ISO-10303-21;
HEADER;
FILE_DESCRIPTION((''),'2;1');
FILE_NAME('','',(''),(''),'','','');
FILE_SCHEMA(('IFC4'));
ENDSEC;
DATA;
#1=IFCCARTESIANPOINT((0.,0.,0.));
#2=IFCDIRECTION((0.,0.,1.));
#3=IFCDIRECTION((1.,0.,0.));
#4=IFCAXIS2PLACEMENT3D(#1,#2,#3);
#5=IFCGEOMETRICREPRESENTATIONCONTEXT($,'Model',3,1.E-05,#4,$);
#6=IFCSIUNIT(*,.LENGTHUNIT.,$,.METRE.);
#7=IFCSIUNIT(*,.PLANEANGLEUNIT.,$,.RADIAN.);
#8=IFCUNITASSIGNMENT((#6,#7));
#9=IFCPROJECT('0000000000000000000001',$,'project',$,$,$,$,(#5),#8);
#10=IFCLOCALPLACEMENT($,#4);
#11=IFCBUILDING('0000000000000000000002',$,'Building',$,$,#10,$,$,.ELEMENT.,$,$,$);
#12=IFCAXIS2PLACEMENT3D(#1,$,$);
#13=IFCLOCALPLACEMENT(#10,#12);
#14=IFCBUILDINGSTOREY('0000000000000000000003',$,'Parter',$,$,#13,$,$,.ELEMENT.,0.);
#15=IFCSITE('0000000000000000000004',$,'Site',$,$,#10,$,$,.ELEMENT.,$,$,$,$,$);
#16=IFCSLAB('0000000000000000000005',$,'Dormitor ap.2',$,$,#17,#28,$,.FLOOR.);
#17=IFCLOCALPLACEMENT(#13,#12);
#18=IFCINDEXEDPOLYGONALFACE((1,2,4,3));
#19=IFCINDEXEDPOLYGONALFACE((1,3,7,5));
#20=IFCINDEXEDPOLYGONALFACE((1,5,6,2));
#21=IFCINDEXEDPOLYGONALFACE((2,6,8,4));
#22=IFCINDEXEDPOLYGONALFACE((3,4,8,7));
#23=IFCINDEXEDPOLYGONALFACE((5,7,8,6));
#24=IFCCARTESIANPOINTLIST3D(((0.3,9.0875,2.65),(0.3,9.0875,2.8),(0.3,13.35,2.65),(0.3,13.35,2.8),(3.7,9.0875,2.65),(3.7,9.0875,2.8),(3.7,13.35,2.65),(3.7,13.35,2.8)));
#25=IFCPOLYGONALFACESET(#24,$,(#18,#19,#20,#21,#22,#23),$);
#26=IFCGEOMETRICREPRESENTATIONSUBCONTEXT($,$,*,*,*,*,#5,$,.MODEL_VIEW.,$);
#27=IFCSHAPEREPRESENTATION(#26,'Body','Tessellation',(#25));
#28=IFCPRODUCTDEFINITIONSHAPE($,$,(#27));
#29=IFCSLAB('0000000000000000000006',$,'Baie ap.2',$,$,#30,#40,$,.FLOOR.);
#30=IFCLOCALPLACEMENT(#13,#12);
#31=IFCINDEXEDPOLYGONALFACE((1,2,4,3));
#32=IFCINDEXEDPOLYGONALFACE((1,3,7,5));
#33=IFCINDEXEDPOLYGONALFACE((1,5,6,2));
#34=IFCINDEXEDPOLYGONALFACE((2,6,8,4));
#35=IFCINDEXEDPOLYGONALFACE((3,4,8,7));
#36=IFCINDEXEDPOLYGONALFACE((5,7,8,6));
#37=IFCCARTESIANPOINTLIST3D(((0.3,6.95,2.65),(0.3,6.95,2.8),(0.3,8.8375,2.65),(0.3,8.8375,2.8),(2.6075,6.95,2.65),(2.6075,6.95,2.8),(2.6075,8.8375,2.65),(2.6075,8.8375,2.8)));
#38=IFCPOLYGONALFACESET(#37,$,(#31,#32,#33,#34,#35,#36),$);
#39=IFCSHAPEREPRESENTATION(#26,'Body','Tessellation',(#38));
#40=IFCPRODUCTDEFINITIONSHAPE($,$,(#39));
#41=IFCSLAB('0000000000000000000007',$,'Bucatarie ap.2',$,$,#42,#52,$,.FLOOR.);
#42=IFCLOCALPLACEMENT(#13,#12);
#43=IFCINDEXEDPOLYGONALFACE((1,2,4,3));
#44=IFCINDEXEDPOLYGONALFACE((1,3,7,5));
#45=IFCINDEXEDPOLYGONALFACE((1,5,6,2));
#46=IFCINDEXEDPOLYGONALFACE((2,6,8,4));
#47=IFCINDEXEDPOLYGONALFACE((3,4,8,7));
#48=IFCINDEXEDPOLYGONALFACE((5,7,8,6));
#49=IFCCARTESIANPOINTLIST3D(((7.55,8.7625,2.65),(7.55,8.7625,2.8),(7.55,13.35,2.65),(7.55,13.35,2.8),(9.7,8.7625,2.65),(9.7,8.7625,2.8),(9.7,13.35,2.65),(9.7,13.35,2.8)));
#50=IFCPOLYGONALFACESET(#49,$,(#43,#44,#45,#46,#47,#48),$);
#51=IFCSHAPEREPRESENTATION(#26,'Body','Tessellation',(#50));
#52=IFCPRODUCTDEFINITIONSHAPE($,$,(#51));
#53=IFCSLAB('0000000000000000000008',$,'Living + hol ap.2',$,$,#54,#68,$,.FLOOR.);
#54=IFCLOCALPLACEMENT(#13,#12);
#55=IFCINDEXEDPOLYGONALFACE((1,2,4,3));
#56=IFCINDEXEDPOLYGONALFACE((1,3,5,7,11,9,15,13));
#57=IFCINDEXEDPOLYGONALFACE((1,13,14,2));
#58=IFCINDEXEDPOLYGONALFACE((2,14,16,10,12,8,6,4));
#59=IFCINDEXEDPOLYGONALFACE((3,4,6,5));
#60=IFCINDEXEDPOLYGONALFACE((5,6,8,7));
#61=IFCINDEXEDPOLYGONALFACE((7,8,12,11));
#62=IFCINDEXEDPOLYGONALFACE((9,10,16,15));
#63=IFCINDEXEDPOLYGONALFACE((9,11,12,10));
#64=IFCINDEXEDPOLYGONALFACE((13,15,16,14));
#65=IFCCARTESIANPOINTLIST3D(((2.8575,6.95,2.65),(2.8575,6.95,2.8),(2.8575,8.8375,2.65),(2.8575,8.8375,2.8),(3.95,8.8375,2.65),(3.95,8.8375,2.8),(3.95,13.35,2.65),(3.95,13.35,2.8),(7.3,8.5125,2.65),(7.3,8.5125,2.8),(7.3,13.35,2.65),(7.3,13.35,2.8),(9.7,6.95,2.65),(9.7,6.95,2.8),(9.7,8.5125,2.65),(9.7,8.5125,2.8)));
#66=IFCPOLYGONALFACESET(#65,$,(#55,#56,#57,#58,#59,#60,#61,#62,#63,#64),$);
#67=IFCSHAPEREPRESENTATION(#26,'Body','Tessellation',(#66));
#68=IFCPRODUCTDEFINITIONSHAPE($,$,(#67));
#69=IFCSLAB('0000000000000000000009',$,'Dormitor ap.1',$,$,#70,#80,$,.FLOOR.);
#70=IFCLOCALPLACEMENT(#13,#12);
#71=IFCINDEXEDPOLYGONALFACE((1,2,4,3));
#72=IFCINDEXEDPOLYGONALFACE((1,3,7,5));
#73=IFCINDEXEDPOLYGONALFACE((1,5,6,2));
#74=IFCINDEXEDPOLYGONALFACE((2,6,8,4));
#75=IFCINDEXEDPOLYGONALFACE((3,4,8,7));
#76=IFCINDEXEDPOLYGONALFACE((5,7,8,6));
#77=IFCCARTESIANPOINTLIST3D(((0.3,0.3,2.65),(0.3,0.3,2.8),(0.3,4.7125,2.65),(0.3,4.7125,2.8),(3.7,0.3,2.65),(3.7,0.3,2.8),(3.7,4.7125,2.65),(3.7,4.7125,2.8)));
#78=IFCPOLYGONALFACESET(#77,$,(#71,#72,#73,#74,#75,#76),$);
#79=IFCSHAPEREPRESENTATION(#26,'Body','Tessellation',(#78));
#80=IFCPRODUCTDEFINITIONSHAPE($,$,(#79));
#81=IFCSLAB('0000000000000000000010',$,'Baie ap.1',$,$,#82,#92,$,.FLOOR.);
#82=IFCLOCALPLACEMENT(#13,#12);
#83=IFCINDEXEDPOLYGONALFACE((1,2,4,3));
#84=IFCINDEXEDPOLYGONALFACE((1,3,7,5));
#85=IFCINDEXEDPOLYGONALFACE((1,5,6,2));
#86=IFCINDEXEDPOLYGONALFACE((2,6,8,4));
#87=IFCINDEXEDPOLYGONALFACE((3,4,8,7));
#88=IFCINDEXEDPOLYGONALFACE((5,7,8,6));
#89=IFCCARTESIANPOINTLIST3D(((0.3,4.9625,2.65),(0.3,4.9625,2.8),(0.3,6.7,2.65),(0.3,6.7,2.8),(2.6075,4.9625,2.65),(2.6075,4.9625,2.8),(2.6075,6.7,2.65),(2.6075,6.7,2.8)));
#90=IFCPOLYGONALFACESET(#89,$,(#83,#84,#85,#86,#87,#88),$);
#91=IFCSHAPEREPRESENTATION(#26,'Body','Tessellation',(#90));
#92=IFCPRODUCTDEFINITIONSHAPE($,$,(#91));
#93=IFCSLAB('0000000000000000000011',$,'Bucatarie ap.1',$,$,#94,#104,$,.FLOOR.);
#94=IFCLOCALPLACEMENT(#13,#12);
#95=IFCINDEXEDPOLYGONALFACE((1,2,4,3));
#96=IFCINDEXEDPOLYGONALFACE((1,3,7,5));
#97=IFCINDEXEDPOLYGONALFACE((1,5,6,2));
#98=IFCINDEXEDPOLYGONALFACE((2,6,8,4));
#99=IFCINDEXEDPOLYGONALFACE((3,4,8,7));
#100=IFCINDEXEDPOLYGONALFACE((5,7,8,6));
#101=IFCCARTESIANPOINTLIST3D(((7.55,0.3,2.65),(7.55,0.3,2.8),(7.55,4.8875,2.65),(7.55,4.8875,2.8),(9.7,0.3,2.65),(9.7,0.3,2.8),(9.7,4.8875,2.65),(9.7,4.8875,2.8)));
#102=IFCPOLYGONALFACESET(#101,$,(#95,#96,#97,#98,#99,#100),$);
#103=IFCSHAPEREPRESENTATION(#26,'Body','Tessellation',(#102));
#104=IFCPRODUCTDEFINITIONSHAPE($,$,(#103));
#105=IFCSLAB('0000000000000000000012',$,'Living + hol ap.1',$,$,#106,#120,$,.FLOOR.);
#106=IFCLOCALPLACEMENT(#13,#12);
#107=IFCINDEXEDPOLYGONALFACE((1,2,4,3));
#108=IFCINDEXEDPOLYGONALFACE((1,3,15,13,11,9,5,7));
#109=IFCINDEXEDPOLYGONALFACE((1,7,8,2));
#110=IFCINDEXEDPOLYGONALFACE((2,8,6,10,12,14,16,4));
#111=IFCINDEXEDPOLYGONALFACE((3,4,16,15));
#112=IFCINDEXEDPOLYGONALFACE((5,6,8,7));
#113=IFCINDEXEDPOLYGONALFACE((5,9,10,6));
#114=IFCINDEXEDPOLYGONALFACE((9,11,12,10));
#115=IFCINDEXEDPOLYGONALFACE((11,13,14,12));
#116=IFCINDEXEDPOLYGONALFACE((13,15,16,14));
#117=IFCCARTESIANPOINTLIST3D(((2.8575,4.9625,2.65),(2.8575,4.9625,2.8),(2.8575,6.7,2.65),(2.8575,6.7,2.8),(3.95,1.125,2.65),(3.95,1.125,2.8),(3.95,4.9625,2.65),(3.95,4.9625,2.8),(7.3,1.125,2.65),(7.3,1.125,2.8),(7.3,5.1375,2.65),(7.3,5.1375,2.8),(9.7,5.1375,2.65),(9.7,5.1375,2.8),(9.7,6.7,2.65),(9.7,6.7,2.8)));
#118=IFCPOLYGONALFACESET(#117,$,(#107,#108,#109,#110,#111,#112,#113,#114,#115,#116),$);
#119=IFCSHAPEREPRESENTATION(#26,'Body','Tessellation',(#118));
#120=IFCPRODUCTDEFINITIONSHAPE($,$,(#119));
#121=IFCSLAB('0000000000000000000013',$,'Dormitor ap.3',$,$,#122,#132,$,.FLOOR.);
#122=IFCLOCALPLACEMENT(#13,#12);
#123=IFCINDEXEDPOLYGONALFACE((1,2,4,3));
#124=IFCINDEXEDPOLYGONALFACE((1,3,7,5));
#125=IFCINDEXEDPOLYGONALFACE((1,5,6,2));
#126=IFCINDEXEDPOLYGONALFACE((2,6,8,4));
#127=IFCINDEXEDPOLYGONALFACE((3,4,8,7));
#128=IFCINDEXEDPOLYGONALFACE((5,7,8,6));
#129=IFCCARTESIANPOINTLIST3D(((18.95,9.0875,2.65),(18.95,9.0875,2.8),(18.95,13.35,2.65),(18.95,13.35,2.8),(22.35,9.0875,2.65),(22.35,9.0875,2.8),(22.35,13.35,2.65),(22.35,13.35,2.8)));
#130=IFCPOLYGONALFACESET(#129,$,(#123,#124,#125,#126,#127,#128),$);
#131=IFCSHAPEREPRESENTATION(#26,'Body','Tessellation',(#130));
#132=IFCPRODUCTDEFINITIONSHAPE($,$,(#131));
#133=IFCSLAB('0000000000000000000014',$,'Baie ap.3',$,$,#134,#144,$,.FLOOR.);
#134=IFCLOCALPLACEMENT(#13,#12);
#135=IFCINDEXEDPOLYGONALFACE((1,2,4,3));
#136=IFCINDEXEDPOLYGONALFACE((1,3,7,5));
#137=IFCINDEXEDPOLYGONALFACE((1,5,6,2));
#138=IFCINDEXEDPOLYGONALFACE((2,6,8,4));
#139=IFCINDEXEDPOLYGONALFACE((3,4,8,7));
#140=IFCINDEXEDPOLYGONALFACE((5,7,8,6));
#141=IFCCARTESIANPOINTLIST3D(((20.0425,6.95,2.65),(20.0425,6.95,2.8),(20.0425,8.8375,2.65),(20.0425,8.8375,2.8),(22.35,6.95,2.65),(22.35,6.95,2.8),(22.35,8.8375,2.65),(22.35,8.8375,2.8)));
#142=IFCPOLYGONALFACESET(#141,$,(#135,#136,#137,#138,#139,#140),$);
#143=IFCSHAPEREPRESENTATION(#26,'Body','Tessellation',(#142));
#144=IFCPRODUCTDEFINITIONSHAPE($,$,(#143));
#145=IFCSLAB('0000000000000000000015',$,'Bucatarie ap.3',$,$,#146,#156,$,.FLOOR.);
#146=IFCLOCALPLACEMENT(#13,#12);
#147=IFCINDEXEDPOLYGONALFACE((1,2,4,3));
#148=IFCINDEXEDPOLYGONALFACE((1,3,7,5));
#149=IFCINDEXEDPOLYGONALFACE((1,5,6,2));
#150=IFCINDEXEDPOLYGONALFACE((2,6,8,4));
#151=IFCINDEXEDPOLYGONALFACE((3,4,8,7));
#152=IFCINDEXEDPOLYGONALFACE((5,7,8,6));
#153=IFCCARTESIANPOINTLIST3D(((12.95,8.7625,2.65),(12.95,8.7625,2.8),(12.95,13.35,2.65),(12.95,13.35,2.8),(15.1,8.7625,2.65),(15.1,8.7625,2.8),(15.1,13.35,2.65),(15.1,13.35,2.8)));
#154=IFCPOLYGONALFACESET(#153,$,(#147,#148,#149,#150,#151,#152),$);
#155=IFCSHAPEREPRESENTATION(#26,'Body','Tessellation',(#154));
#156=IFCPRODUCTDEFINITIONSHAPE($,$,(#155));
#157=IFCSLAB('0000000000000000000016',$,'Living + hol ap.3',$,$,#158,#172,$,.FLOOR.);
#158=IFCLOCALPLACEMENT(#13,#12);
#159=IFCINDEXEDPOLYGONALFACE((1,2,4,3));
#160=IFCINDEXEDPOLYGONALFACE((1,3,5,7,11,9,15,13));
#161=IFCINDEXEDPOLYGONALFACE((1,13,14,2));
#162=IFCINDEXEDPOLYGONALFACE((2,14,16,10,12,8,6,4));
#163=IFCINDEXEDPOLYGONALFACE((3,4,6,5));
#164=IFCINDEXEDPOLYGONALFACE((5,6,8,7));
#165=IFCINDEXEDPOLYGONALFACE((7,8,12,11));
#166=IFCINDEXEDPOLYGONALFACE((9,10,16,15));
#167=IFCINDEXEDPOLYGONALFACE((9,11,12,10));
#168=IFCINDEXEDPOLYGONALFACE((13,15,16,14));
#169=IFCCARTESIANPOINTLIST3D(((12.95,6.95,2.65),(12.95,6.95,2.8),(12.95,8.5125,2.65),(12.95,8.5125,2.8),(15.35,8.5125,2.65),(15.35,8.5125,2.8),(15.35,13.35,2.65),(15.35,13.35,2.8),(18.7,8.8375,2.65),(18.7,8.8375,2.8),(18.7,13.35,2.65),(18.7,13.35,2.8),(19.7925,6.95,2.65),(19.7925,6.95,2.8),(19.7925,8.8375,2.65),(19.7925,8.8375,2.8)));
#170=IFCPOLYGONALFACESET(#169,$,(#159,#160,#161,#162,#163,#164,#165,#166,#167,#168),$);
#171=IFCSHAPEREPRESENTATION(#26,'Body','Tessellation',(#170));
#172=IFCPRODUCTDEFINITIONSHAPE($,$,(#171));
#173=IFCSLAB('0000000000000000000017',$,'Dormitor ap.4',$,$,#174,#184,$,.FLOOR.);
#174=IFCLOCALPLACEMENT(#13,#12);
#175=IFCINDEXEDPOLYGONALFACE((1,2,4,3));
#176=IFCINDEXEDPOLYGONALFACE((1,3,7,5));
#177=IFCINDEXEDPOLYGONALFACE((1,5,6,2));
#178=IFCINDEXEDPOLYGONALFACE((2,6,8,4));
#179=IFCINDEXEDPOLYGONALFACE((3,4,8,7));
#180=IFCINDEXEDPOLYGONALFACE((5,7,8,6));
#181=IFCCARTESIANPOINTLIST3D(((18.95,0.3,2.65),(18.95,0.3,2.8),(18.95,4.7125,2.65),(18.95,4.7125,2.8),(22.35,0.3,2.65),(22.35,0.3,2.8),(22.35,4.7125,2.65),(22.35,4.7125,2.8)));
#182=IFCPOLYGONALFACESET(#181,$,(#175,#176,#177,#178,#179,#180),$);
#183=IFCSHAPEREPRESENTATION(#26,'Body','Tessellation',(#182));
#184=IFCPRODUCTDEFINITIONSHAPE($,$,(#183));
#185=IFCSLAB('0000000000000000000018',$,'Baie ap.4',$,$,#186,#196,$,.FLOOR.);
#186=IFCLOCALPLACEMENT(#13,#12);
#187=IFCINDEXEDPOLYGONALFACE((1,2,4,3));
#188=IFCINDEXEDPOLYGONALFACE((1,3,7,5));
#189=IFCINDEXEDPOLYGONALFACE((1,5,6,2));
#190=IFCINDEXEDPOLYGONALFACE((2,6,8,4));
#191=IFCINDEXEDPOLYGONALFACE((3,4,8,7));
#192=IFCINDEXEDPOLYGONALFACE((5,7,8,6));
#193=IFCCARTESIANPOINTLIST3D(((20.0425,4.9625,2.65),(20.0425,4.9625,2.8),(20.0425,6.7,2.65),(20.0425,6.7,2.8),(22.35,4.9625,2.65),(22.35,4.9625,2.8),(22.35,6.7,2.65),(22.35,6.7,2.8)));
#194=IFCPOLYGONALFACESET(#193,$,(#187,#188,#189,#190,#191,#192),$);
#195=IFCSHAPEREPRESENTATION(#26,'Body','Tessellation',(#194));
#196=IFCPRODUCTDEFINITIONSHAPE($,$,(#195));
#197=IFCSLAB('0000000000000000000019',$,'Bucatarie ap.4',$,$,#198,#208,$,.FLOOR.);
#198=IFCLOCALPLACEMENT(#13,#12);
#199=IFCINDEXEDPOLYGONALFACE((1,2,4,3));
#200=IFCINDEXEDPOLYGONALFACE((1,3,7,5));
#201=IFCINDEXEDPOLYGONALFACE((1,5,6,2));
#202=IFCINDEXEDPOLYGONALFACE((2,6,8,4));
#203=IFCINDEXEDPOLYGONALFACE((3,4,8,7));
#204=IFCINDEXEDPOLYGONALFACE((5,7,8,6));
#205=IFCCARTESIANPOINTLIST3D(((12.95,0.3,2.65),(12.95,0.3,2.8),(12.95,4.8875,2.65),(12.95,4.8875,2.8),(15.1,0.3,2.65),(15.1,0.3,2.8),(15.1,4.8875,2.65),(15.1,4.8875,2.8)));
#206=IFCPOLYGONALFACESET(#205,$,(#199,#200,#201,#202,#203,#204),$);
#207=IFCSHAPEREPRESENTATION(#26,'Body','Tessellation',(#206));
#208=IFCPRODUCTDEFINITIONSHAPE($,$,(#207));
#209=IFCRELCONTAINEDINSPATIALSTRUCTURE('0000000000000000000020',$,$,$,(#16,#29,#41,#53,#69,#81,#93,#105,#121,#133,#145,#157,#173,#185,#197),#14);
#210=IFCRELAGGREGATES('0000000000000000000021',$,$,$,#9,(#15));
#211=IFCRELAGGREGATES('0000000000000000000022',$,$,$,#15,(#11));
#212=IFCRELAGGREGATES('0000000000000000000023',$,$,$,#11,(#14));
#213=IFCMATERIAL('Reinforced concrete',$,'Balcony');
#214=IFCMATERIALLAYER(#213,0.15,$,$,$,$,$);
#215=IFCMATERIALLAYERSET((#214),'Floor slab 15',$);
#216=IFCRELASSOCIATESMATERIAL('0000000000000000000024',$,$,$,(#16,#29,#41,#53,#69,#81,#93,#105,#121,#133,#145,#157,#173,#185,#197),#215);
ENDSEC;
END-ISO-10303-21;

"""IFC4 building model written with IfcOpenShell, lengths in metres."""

from ifc_helpers import new_model, si_unit, frame, origin, origin_with_axes, place, context, subcontext, project, spatial, polyline, outline, extrude, material, layer, layer_set, layer_usage, element, save


model = new_model("IFC4")

# Units and contexts
model_context = context("Model", 3, precision=1e-05, world=origin_with_axes())
sub_context = subcontext(model_context, None, None, "MODEL_VIEW")
ifc_project = project(units=[si_unit("LENGTHUNIT", "METRE"), si_unit("PLANEANGLEUNIT", "RADIAN")], contexts=[model_context])

# Site, building, storey
placement = place(None, origin_with_axes())
site = spatial("IfcSite", under=ifc_project, at=placement, Name="Site", CompositionType="ELEMENT")
building = spatial("IfcBuilding", under=site, at=placement, Name="Building", CompositionType="ELEMENT")
storey_placement = place(placement, origin())
storey = spatial("IfcBuildingStorey", under=building, at=storey_placement, Name="Parter", CompositionType="ELEMENT", Elevation=0.0)

# Slabs
ifc_material_1 = material(Name="Reinforced concrete", Category="Balcony")
ifc_layer = layer(ifc_material_1, 0.15)
ifc_layer_set = layer_set([ifc_layer], Name="Floor slab 15")
ifc_layer_usage = layer_usage(ifc_layer_set, "AXIS3", "POSITIVE", 0.0)
slab_1_placement = place(storey_placement, frame((0.0, 0.0, 2.65)))
element("IfcSlab", 1, at=slab_1_placement, inside=storey, material=ifc_layer_usage, Name="Dormitor ap.2", PredefinedType="FLOOR", context=sub_context, shape_type="SweptSolid", body=[
    extrude(outline(polyline([(3.7, 13.35), (0.3, 13.35), (0.3, 9.0875), (3.7, 9.0875), (3.7, 13.35)])), origin(), (0.0, 0.0, 1.0), 0.15),
])
slab_2_placement = place(storey_placement, frame((0.0, 0.0, 2.65)))
element("IfcSlab", 2, at=slab_2_placement, inside=storey, material=ifc_layer_usage, Name="Baie ap.2", PredefinedType="FLOOR", context=sub_context, shape_type="SweptSolid", body=[
    extrude(outline(polyline([(2.6075, 8.8375), (0.3, 8.8375), (0.3, 6.95), (2.6075, 6.95), (2.6075, 8.8375)])), origin(), (0.0, 0.0, 1.0), 0.15),
])
slab_3_placement = place(storey_placement, frame((0.0, 0.0, 2.65)))
element("IfcSlab", 3, at=slab_3_placement, inside=storey, material=ifc_layer_usage, Name="Bucatarie ap.2", PredefinedType="FLOOR", context=sub_context, shape_type="SweptSolid", body=[
    extrude(outline(polyline([(7.55, 13.35), (7.55, 8.7625), (9.7, 8.7625), (9.7, 13.35), (7.55, 13.35)])), origin(), (0.0, 0.0, 1.0), 0.15),
])
slab_4_placement = place(storey_placement, frame((0.0, 0.0, 2.65)))
element("IfcSlab", 4, at=slab_4_placement, inside=storey, material=ifc_layer_usage, Name="Living + hol ap.2", PredefinedType="FLOOR", context=sub_context, shape_type="SweptSolid", body=[
    extrude(outline(polyline([(7.3, 13.35), (3.95, 13.35), (3.95, 8.8375), (2.8575, 8.8375), (2.8575, 6.95), (9.7, 6.95), (9.7, 8.5125), (7.3, 8.5125), (7.3, 13.35)])), origin(), (0.0, 0.0, 1.0), 0.15),
])
slab_5_placement = place(storey_placement, frame((0.0, 0.0, 2.65)))
element("IfcSlab", 5, at=slab_5_placement, inside=storey, material=ifc_layer_usage, Name="Dormitor ap.1", PredefinedType="FLOOR", context=sub_context, shape_type="SweptSolid", body=[
    extrude(outline(polyline([(0.3, 4.7125), (0.3, 0.3), (3.7, 0.3), (3.7, 4.7125), (0.3, 4.7125)])), origin(), (0.0, 0.0, 1.0), 0.15),
])
slab_6_placement = place(storey_placement, frame((0.0, 0.0, 2.65)))
element("IfcSlab", 6, at=slab_6_placement, inside=storey, material=ifc_layer_usage, Name="Baie ap.1", PredefinedType="FLOOR", context=sub_context, shape_type="SweptSolid", body=[
    extrude(outline(polyline([(2.6075, 6.7), (0.3, 6.7), (0.3, 4.9625), (2.6075, 4.9625), (2.6075, 6.7)])), origin(), (0.0, 0.0, 1.0), 0.15),
])
slab_7_placement = place(storey_placement, frame((0.0, 0.0, 2.65)))
element("IfcSlab", 7, at=slab_7_placement, inside=storey, material=ifc_layer_usage, Name="Bucatarie ap.1", PredefinedType="FLOOR", context=sub_context, shape_type="SweptSolid", body=[
    extrude(outline(polyline([(7.55, 4.8875), (7.55, 0.3), (9.7, 0.3), (9.7, 4.8875), (7.55, 4.8875)])), origin(), (0.0, 0.0, 1.0), 0.15),
])
slab_8_placement = place(storey_placement, frame((0.0, 0.0, 2.65)))
element("IfcSlab", 8, at=slab_8_placement, inside=storey, material=ifc_layer_usage, Name="Living + hol ap.1", PredefinedType="FLOOR", context=sub_context, shape_type="SweptSolid", body=[
    extrude(outline(polyline([(7.3, 5.1375), (9.7, 5.1375), (9.7, 6.7), (2.8575, 6.7), (2.8575, 4.9625), (3.95, 4.9625), (3.95, 1.125), (7.3, 1.125), (7.3, 5.1375)])), origin(), (0.0, 0.0, 1.0), 0.15),
])
slab_9_placement = place(storey_placement, frame((0.0, 0.0, 2.65)))
element("IfcSlab", 9, at=slab_9_placement, inside=storey, material=ifc_layer_usage, Name="Dormitor ap.3", PredefinedType="FLOOR", context=sub_context, shape_type="SweptSolid", body=[
    extrude(outline(polyline([(22.35, 13.35), (18.95, 13.35), (18.95, 9.0875), (22.35, 9.0875), (22.35, 13.35)])), origin(), (0.0, 0.0, 1.0), 0.15),
])
slab_10_placement = place(storey_placement, frame((0.0, 0.0, 2.65)))
element("IfcSlab", 10, at=slab_10_placement, inside=storey, material=ifc_layer_usage, Name="Baie ap.3", PredefinedType="FLOOR", context=sub_context, shape_type="SweptSolid", body=[
    extrude(outline(polyline([(22.35, 8.8375), (20.0425, 8.8375), (20.0425, 6.95), (22.35, 6.95), (22.35, 8.8375)])), origin(), (0.0, 0.0, 1.0), 0.15),
])
slab_11_placement = place(storey_placement, frame((0.0, 0.0, 2.65)))
element("IfcSlab", 11, at=slab_11_placement, inside=storey, material=ifc_layer_usage, Name="Bucatarie ap.3", PredefinedType="FLOOR", context=sub_context, shape_type="SweptSolid", body=[
    extrude(outline(polyline([(15.1, 13.35), (12.95, 13.35), (12.95, 8.7625), (15.1, 8.7625), (15.1, 13.35)])), origin(), (0.0, 0.0, 1.0), 0.15),
])
slab_12_placement = place(storey_placement, frame((0.0, 0.0, 2.65)))
element("IfcSlab", 12, at=slab_12_placement, inside=storey, material=ifc_layer_usage, Name="Living + hol ap.3", PredefinedType="FLOOR", context=sub_context, shape_type="SweptSolid", body=[
    extrude(outline(polyline([(15.35, 13.35), (15.35, 8.5125), (12.95, 8.5125), (12.95, 6.95), (19.7925, 6.95), (19.7925, 8.8375), (18.7, 8.8375), (18.7, 13.35), (15.35, 13.35)])), origin(), (0.0, 0.0, 1.0), 0.15),
])
slab_13_placement = place(storey_placement, frame((0.0, 0.0, 2.65)))
element("IfcSlab", 13, at=slab_13_placement, inside=storey, material=ifc_layer_usage, Name="Dormitor ap.4", PredefinedType="FLOOR", context=sub_context, shape_type="SweptSolid", body=[
    extrude(outline(polyline([(22.35, 4.7125), (18.95, 4.7125), (18.95, 0.3), (22.35, 0.3), (22.35, 4.7125)])), origin(), (0.0, 0.0, 1.0), 0.15),
])
slab_14_placement = place(storey_placement, frame((0.0, 0.0, 2.65)))
element("IfcSlab", 14, at=slab_14_placement, inside=storey, material=ifc_layer_usage, Name="Baie ap.4", PredefinedType="FLOOR", context=sub_context, shape_type="SweptSolid", body=[
    extrude(outline(polyline([(22.35, 6.7), (20.0425, 6.7), (20.0425, 4.9625), (22.35, 4.9625), (22.35, 6.7)])), origin(), (0.0, 0.0, 1.0), 0.15),
])
slab_15_placement = place(storey_placement, frame((0.0, 0.0, 2.65)))
element("IfcSlab", 15, at=slab_15_placement, inside=storey, material=ifc_layer_usage, Name="Bucatarie ap.4", PredefinedType="FLOOR", context=sub_context, shape_type="SweptSolid", body=[
    extrude(outline(polyline([(12.95, 4.8875), (12.95, 0.3), (15.1, 0.3), (15.1, 4.8875), (12.95, 4.8875)])), origin(), (0.0, 0.0, 1.0), 0.15),
])

save(model, "model.ifc")
